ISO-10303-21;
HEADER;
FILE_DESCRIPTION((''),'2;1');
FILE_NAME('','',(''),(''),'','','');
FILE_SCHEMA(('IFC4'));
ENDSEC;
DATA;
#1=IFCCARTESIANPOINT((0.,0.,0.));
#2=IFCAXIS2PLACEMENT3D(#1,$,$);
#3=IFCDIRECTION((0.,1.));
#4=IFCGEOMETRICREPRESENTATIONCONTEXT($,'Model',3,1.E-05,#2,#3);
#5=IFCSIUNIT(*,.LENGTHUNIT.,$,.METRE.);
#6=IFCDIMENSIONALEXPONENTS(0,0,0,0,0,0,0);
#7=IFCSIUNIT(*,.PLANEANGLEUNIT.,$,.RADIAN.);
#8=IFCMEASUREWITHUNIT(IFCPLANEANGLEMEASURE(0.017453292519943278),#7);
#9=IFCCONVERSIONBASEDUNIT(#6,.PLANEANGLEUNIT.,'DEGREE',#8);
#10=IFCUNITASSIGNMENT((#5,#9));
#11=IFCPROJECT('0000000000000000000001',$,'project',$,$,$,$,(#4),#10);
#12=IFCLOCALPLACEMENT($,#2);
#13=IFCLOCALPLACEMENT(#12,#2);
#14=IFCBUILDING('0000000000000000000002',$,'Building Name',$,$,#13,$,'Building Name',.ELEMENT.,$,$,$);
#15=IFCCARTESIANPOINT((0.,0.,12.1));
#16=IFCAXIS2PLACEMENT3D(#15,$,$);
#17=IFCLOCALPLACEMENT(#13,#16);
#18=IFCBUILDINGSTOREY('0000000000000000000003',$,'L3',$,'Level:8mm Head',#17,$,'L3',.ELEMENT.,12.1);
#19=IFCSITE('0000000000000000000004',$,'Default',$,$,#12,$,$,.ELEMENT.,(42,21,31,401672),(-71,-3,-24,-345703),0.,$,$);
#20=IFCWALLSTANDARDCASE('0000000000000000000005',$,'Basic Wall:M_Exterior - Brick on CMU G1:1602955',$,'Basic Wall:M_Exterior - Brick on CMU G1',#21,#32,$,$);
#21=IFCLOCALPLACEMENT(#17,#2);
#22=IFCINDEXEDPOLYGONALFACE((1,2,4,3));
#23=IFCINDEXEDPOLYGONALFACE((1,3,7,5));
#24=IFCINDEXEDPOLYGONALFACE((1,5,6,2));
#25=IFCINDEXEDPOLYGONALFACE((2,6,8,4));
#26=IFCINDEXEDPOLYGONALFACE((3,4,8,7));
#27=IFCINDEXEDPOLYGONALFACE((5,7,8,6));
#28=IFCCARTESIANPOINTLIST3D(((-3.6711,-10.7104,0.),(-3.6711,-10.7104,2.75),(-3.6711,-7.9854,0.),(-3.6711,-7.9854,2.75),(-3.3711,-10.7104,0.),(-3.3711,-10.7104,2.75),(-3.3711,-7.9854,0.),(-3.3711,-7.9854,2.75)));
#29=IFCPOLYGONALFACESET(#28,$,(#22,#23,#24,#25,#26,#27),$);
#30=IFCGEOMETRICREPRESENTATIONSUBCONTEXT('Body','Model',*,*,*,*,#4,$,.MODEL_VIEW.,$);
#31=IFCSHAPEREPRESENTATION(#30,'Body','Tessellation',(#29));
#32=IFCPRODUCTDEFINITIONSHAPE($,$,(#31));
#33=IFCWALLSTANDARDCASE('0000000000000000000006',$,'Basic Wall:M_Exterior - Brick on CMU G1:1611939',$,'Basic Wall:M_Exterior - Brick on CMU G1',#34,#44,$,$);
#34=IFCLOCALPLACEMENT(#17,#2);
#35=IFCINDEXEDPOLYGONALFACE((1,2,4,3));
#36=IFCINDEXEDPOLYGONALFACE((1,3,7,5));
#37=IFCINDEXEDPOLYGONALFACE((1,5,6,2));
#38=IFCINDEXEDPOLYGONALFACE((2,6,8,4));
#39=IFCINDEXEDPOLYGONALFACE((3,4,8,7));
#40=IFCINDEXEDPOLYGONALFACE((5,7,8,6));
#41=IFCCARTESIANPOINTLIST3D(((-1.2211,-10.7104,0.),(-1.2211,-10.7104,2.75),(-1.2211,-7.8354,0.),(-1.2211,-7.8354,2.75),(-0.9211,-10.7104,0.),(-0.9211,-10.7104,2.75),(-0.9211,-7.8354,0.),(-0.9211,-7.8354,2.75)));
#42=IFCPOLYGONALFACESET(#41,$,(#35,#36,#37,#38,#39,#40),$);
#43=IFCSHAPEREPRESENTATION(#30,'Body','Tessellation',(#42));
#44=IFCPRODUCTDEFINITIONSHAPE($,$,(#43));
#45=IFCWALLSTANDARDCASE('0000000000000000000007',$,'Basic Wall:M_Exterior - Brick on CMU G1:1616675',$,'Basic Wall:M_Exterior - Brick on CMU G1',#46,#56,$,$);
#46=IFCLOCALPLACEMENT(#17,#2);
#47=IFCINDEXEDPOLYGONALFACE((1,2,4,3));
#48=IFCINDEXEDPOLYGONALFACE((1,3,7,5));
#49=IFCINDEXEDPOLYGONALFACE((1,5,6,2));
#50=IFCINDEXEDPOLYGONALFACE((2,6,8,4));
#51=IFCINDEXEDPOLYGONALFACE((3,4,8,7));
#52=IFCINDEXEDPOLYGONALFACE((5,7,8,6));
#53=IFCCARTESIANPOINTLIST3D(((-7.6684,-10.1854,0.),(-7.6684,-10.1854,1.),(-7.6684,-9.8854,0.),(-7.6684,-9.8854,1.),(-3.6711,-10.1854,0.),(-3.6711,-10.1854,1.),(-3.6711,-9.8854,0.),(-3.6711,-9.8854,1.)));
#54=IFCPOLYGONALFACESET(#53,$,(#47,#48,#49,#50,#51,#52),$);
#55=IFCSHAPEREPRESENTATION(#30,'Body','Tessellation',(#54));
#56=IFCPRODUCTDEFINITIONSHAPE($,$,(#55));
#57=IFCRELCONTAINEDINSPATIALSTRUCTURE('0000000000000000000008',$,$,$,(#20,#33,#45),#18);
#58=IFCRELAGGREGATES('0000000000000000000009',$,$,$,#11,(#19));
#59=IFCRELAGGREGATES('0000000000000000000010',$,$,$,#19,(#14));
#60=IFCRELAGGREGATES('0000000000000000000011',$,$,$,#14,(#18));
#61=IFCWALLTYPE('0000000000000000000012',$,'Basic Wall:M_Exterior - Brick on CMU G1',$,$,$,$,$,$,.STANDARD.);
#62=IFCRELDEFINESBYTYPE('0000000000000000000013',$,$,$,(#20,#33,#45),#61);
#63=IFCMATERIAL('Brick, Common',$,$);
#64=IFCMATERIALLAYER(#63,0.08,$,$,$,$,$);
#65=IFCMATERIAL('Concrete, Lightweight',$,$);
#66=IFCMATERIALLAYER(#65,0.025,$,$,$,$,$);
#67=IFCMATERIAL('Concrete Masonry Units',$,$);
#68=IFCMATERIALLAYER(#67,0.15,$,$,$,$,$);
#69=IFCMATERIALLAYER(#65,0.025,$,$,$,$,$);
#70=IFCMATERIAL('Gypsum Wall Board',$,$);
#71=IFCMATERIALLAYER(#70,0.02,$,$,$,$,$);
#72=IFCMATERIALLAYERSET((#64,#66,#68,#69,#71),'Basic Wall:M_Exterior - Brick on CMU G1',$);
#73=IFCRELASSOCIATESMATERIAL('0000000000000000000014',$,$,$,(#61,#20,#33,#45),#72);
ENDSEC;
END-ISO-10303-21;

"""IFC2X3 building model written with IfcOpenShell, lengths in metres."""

from ifc_helpers import new_model, entity, si_unit, converted_unit, direction, frame, frame_2d, origin, place, context, subcontext, project, spatial, rectangle, extrude, material, layer, layer_set, layer_usage, type_object, element, save


model = new_model("IFC2X3")

# Units and contexts
model_context = context("Model", 3, precision=1e-05, world=origin(), true_north=direction((0.0, 1.0)))
body_context = subcontext(model_context, "Body", "Model", "MODEL_VIEW")
ifc_project = project(units=[si_unit("LENGTHUNIT", "METRE"), converted_unit("PLANEANGLEUNIT", "DEGREE", entity("IfcPlaneAngleMeasure", 0.017453292519943278), si_unit("PLANEANGLEUNIT", "RADIAN"), dimensions=[0, 0, 0, 0, 0, 0, 0])], contexts=[model_context])

# Site, building, storey
site_placement = place(None, origin())
site = spatial("IfcSite", under=ifc_project, at=site_placement, Name="Default", CompositionType="ELEMENT", RefLatitude=(42, 21, 31, 401672), RefLongitude=(-71, -3, -24, -345703), RefElevation=0.0)
building_placement = place(site_placement, origin())
building = spatial("IfcBuilding", under=site, at=building_placement, Name="Building Name", LongName="Building Name", CompositionType="ELEMENT")
storey_placement = place(building_placement, frame((0.0, 0.0, 12.1)))
storey = spatial("IfcBuildingStorey", under=building, at=storey_placement, Name="L3", ObjectType="Level:8mm Head", LongName="L3", CompositionType="ELEMENT", Elevation=12.1)

# Walls
ifc_material_1 = material(Name="Brick, Common")
ifc_layer_1 = layer(ifc_material_1, 0.08)
ifc_material_2 = material(Name="Concrete, Lightweight")
ifc_layer_2 = layer(ifc_material_2, 0.025)
ifc_material_3 = material(Name="Concrete Masonry Units")
ifc_layer_3 = layer(ifc_material_3, 0.15)
ifc_layer_4 = layer(ifc_material_2, 0.025)
ifc_material_4 = material(Name="Gypsum Wall Board")
ifc_layer_5 = layer(ifc_material_4, 0.02)
ifc_layer_set = layer_set([ifc_layer_1, ifc_layer_2, ifc_layer_3, ifc_layer_4, ifc_layer_5], Name="Basic Wall:M_Exterior - Brick on CMU G1")
wall_type = type_object("IfcWallType", Name="Basic Wall:M_Exterior - Brick on CMU G1", PredefinedType="STANDARD", material=ifc_layer_set)
ifc_layer_usage_1 = layer_usage(ifc_layer_set, "AXIS2", "NEGATIVE", 0.15)
wall_1_placement = place(storey_placement, frame((-3.5211, -10.7104, 0.0), z_axis=(0.0, 0.0, 1.0), x_axis=(0.0, 1.0, 0.0)))
element("IfcWallStandardCase", 1, at=wall_1_placement, inside=storey, type_object=wall_type, material=ifc_layer_usage_1, Name="Basic Wall:M_Exterior - Brick on CMU G1:1602955", ObjectType="Basic Wall:M_Exterior - Brick on CMU G1", context=body_context, shape_type="SweptSolid", body=[
    extrude(rectangle(XDim=2.725, YDim=0.3, at=frame_2d((1.3625, 0.0), x_axis=(-1.0, 0.0))), origin(), (0.0, 0.0, 1.0), 2.75),
])
ifc_layer_usage_2 = layer_usage(ifc_layer_set, "AXIS2", "NEGATIVE", 0.15)
wall_2_placement = place(storey_placement, frame((-1.0711, -7.8354, 0.0), z_axis=(0.0, 0.0, 1.0), x_axis=(0.0, -1.0, 0.0)))
element("IfcWallStandardCase", 2, at=wall_2_placement, inside=storey, type_object=wall_type, material=ifc_layer_usage_2, Name="Basic Wall:M_Exterior - Brick on CMU G1:1611939", ObjectType="Basic Wall:M_Exterior - Brick on CMU G1", context=body_context, shape_type="SweptSolid", body=[
    extrude(rectangle(XDim=2.875, YDim=0.3, at=frame_2d((1.4375, 0.0), x_axis=(-1.0, 0.0))), origin(), (0.0, 0.0, 1.0), 2.75),
])
ifc_layer_usage_3 = layer_usage(ifc_layer_set, "AXIS2", "POSITIVE", -0.15)
wall_3_placement = place(storey_placement, frame((-7.6684, -10.0354, 0.0)))
element("IfcWallStandardCase", 3, at=wall_3_placement, inside=storey, type_object=wall_type, material=ifc_layer_usage_3, Name="Basic Wall:M_Exterior - Brick on CMU G1:1616675", ObjectType="Basic Wall:M_Exterior - Brick on CMU G1", context=body_context, shape_type="SweptSolid", body=[
    extrude(rectangle(XDim=3.9973, YDim=0.3, at=frame_2d((1.9987, 0.0), x_axis=(-1.0, 0.0))), origin(), (0.0, 0.0, 1.0), 1.0),
])

save(model, "model.ifc")
